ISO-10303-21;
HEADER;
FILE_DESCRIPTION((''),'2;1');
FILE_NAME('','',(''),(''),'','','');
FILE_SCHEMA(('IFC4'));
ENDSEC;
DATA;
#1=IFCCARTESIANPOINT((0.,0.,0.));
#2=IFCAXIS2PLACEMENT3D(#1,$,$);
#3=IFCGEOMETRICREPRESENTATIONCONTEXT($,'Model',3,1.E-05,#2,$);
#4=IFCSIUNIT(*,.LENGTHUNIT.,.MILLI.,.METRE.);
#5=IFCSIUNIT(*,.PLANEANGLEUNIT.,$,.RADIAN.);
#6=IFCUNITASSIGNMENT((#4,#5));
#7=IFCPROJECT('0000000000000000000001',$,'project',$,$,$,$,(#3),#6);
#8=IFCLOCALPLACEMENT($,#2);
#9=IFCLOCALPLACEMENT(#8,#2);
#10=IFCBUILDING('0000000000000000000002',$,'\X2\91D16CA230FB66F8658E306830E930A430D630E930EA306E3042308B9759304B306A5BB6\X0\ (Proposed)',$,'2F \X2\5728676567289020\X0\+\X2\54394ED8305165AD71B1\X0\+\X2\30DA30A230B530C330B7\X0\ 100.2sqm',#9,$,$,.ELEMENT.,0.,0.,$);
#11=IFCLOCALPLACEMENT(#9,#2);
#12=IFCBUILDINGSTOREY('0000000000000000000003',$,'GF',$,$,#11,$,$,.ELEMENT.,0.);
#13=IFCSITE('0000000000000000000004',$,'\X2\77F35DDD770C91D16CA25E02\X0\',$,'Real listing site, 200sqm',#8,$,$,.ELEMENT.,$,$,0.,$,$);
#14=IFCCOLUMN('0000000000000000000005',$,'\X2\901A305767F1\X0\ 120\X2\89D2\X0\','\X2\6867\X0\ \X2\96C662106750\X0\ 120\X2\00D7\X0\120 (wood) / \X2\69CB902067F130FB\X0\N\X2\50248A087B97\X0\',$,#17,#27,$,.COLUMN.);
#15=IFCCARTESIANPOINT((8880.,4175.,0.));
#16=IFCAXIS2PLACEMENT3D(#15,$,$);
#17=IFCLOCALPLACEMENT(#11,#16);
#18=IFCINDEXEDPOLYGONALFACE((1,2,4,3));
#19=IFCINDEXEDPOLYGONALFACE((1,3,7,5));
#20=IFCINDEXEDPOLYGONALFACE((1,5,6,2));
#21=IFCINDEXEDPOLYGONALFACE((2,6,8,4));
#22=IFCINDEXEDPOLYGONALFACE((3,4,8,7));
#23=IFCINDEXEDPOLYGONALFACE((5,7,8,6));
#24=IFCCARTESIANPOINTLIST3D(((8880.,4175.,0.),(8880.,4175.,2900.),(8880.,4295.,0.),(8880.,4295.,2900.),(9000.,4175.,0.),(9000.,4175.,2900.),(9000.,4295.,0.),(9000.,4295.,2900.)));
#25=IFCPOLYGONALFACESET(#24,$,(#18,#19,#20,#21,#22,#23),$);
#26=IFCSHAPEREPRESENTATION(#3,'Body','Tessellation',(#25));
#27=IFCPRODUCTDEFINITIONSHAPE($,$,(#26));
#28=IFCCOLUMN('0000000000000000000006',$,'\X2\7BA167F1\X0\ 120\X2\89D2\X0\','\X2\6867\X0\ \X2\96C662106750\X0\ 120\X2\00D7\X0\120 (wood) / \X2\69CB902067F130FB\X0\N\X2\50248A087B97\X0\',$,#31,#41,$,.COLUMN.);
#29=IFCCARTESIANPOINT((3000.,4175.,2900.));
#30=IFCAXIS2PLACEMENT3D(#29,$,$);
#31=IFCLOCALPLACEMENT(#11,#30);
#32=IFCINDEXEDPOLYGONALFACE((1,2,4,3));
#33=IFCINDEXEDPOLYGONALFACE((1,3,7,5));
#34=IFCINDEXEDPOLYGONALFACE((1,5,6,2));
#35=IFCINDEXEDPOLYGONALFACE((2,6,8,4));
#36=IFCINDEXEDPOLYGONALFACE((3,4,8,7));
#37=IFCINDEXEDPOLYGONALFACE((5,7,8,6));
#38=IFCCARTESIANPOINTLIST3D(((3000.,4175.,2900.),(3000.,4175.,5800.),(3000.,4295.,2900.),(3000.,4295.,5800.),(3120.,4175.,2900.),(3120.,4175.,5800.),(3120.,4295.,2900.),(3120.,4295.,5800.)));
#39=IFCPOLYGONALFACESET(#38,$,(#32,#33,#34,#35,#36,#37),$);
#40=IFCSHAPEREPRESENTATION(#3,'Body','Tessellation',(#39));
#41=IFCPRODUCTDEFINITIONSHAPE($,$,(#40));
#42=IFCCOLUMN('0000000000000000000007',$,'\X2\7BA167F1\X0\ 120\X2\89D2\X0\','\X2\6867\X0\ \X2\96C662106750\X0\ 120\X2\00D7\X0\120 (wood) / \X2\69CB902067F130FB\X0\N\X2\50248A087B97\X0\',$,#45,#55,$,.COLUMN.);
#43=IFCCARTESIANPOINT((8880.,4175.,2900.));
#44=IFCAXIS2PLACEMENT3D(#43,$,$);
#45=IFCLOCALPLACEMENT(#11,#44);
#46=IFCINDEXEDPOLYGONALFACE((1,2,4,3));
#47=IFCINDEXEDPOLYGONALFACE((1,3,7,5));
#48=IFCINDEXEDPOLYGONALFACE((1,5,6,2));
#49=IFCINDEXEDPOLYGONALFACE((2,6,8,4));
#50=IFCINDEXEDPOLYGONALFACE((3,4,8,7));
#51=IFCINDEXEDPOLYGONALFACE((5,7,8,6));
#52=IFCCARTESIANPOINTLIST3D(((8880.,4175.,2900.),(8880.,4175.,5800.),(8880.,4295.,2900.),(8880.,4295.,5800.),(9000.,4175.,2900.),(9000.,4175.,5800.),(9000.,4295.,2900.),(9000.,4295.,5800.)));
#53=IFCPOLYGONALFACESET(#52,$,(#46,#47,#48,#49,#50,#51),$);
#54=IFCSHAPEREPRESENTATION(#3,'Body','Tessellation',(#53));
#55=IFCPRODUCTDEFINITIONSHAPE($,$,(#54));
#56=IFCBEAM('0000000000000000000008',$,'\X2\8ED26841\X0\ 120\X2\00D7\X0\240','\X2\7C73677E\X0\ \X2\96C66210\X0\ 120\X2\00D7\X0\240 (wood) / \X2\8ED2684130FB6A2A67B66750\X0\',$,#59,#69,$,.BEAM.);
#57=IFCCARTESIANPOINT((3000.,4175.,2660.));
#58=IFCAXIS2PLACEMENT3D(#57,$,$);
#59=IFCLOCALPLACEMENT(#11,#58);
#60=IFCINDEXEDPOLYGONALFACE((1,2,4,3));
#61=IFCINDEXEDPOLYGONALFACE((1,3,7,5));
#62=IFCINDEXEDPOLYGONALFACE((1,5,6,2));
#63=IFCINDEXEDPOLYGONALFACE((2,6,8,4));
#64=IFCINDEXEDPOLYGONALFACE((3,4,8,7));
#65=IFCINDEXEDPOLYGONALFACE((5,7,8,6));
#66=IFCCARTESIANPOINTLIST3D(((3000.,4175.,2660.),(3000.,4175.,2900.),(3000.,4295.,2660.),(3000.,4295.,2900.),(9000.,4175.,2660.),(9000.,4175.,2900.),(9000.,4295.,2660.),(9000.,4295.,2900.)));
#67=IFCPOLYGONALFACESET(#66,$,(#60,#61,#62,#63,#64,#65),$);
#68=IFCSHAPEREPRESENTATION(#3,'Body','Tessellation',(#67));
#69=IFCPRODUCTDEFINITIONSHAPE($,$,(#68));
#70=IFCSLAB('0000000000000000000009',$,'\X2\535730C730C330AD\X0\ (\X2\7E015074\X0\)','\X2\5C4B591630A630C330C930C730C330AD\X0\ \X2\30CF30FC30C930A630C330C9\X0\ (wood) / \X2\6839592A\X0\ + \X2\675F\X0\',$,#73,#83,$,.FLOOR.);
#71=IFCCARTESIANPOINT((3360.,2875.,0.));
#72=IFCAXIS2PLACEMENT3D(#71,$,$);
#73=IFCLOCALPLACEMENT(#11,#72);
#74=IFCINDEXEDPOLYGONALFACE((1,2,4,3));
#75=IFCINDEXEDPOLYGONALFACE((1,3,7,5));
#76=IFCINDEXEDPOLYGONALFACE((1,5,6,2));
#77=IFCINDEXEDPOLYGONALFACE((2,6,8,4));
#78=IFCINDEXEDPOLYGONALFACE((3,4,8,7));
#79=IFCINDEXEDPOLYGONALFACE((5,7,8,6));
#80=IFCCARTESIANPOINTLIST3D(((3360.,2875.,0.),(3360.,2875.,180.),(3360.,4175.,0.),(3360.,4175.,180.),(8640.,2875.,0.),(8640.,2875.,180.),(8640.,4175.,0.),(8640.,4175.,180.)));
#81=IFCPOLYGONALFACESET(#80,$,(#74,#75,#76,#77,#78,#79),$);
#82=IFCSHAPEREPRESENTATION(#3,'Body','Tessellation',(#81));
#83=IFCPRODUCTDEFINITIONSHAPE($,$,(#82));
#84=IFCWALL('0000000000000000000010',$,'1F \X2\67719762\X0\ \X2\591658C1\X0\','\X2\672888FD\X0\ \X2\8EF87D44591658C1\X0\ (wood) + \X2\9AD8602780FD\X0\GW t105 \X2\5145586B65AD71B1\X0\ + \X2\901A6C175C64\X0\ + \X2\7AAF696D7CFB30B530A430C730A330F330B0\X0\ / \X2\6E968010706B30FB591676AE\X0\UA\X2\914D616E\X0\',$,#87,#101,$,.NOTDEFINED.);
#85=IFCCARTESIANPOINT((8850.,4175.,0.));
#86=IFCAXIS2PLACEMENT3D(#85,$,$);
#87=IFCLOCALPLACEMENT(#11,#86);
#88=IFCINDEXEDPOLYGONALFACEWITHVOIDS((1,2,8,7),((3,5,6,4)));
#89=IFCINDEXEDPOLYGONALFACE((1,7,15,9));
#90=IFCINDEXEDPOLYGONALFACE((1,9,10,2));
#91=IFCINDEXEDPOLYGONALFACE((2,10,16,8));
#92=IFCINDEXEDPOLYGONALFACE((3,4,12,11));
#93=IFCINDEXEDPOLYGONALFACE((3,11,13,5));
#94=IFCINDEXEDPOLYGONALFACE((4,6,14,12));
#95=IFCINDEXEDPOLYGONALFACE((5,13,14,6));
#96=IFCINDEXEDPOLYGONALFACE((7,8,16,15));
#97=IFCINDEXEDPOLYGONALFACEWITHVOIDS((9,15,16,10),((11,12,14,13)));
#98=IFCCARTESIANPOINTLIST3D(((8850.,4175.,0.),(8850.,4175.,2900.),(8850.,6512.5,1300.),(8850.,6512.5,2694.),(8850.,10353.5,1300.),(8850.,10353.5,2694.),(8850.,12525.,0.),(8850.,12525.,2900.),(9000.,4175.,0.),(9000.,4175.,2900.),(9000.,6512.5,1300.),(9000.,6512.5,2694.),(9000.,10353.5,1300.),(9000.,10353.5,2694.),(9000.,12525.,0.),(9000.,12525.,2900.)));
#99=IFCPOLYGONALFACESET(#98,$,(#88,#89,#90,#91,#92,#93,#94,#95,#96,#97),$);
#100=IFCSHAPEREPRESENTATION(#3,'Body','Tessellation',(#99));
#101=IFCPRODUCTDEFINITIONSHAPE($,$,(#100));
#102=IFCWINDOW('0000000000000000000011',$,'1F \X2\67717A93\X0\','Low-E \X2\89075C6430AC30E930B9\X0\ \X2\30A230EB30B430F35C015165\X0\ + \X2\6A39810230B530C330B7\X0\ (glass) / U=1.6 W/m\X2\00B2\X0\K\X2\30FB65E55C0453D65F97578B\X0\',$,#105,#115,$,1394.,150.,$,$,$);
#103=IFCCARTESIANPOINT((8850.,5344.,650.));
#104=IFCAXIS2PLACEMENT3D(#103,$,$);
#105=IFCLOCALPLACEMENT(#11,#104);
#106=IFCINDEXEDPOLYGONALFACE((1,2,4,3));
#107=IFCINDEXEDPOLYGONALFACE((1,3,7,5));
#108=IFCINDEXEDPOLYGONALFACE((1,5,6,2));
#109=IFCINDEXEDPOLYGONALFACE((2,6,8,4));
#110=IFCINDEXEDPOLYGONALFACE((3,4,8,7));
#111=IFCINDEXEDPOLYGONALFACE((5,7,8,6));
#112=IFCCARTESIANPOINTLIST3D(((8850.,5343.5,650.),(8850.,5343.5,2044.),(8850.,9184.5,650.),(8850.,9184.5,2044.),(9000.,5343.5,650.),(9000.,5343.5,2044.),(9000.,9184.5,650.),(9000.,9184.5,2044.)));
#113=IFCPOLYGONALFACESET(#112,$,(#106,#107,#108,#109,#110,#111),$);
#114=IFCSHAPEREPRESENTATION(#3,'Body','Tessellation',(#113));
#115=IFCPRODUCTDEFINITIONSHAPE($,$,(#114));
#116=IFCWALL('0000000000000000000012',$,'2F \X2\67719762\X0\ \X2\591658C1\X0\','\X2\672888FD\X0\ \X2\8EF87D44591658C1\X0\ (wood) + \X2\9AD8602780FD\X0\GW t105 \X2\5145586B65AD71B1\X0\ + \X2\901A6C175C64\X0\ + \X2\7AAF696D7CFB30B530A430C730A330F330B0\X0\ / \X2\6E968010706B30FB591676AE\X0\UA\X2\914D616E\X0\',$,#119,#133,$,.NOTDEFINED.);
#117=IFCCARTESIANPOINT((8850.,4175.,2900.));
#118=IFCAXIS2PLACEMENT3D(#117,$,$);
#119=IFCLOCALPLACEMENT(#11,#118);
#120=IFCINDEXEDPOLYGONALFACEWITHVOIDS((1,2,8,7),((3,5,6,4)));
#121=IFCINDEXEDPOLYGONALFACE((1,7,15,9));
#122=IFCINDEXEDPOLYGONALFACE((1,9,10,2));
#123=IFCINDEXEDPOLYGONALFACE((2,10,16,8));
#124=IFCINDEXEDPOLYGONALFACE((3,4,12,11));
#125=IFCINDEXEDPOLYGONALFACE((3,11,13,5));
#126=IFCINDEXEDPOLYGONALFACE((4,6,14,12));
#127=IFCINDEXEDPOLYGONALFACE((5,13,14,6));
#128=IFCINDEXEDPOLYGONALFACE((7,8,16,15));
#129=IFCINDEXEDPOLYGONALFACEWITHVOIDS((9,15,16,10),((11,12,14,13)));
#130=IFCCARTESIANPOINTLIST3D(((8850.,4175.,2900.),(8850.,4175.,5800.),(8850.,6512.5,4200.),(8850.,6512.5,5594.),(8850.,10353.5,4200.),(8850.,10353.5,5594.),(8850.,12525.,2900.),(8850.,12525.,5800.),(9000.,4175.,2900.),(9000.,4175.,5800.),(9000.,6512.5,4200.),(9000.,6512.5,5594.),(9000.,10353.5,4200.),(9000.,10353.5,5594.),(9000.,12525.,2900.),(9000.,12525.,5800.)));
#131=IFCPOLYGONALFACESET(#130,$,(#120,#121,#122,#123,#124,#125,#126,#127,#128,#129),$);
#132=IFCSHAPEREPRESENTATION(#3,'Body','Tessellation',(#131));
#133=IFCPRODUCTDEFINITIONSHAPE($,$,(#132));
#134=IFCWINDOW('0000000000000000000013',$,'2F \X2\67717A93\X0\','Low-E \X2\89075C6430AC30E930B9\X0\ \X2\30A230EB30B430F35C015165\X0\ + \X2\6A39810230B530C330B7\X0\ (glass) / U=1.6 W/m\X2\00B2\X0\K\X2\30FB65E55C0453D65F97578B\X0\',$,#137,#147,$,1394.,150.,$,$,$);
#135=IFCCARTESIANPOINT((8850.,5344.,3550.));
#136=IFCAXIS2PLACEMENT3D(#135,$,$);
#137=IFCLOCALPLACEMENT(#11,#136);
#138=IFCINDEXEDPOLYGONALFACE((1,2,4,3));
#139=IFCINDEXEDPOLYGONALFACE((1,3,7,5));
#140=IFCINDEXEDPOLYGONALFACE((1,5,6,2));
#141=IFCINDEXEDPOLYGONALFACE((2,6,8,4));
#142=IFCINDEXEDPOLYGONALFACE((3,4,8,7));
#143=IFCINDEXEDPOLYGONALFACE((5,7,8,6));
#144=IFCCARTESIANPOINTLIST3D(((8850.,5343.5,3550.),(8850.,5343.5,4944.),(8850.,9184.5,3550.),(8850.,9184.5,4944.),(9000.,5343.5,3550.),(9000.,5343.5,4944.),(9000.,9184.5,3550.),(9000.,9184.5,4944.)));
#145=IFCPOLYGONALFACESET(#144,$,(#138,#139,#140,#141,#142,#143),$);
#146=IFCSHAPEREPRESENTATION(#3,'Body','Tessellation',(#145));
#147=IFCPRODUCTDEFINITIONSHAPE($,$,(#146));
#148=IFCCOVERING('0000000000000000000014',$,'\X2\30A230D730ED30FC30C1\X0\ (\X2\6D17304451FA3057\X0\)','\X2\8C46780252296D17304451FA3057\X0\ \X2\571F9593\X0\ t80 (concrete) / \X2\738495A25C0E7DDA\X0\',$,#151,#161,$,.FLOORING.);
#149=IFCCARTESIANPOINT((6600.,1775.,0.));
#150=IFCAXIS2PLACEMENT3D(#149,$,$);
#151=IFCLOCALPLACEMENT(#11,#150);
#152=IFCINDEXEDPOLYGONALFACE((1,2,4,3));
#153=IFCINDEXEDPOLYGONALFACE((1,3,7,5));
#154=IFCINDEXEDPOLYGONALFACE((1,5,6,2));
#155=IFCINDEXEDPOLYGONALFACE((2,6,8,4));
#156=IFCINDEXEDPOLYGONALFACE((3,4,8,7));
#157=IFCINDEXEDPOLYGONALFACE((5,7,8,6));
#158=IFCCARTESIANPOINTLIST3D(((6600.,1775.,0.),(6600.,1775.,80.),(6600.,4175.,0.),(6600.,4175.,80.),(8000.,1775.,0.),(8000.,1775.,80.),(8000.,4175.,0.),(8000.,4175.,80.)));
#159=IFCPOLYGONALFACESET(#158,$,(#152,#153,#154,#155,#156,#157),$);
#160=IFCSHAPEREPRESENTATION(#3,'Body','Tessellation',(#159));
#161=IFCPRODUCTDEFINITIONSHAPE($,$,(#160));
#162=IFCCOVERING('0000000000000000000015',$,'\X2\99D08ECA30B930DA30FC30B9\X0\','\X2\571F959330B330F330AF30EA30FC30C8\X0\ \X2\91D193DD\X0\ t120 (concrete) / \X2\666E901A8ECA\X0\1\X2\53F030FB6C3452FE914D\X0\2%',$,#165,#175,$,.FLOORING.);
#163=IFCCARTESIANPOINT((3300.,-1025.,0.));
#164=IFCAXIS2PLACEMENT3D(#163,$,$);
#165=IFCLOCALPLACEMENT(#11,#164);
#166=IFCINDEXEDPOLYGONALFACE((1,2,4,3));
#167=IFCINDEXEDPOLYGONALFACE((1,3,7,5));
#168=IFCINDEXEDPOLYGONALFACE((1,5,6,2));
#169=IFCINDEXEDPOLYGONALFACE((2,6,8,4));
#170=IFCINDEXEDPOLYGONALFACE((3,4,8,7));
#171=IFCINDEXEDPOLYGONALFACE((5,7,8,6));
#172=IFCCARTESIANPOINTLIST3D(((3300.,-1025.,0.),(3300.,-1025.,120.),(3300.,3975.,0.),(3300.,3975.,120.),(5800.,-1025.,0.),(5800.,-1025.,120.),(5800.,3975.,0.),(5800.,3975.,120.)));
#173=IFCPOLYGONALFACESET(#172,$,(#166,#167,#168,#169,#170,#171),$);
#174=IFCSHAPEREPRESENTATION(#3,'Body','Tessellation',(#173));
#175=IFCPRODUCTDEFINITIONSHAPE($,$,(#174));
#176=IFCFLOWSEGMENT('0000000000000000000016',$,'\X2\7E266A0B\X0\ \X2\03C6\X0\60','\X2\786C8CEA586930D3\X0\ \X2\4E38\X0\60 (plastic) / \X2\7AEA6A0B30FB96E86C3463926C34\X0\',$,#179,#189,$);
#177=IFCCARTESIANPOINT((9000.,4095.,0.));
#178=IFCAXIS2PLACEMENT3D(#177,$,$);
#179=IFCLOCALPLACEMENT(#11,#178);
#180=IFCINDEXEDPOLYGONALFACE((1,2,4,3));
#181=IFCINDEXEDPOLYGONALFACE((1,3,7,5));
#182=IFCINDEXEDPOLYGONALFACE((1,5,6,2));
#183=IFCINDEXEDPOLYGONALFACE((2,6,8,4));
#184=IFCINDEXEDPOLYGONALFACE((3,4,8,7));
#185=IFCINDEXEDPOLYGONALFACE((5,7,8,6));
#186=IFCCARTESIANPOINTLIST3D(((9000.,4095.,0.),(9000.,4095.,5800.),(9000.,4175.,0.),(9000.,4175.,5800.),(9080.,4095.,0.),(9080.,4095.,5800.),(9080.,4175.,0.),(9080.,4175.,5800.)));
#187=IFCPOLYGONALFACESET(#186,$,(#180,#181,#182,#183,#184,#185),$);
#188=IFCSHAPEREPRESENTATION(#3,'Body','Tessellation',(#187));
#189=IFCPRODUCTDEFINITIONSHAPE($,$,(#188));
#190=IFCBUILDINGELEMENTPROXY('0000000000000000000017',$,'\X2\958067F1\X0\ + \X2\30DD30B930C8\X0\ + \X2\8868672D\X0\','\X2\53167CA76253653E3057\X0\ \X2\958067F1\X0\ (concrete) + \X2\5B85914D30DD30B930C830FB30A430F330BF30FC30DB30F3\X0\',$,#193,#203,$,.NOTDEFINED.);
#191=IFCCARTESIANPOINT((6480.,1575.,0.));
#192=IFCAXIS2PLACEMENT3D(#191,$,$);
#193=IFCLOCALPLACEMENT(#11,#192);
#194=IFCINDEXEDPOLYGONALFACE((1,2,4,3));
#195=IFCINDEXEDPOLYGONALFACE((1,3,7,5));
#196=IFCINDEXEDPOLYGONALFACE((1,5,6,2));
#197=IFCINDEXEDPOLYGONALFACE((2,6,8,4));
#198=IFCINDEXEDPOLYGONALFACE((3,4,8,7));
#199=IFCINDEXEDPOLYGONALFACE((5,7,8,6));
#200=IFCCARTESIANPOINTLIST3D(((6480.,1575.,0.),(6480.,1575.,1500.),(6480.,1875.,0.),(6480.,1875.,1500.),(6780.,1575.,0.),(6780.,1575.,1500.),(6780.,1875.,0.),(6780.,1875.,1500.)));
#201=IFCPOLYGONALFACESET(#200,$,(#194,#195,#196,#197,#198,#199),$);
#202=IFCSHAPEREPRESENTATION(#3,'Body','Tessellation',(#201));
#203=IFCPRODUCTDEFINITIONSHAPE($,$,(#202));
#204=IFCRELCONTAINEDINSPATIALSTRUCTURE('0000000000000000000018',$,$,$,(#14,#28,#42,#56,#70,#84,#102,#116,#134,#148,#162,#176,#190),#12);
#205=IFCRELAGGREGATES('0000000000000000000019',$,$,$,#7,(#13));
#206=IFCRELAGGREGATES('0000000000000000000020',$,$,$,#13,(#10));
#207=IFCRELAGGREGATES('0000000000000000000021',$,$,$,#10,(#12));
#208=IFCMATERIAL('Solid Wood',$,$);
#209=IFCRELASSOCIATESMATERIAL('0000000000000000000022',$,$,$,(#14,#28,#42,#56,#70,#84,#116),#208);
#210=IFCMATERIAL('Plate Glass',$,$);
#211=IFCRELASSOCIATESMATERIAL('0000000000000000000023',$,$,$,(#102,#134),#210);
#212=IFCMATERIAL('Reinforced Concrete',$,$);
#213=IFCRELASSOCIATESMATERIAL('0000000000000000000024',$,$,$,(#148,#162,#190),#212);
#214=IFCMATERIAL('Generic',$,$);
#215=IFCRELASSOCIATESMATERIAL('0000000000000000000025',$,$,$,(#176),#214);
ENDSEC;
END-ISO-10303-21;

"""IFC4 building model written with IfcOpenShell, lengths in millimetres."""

from ifc_helpers import new_model, si_unit, frame, frame_2d, origin, place, context, project, spatial, rectangle, extrude, material, element, fill, save


model = new_model("IFC4")

# Units and contexts
model_context = context("Model", 3, precision=1e-05, world=origin())
ifc_project = project(units=[si_unit("LENGTHUNIT", "METRE", prefix="MILLI"), si_unit("PLANEANGLEUNIT", "RADIAN")], contexts=[model_context])

# Site, building, storey
site_placement = place(None, origin())
site = spatial("IfcSite", under=ifc_project, at=site_placement, Name="石川県金沢市", ObjectType="Real listing site, 200sqm", CompositionType="ELEMENT", RefElevation=0.0)
building_placement = place(site_placement, origin())
building = spatial("IfcBuilding", under=site, at=building_placement, Name="金沢・書斎とライブラリのある静かな家 (Proposed)", ObjectType="2F 在来木造+吹付け断熱+ペアサッシ 100.2sqm", CompositionType="ELEMENT", ElevationOfRefHeight=0.0, ElevationOfTerrain=0.0)
storey_placement = place(building_placement, origin())
storey = spatial("IfcBuildingStorey", under=building, at=storey_placement, Name="GF", CompositionType="ELEMENT", Elevation=0.0)

# Columns
ifc_material_1 = material(Name="Solid Wood")
column_1_placement = place(storey_placement, frame((8880.0, 4175.0, 0.0)))
element("IfcColumn", 1, at=column_1_placement, inside=storey, material=ifc_material_1, Name="通し柱 120角", Description="桧 集成材 120×120 (wood) / 構造柱・N値計算", PredefinedType="COLUMN", context=model_context, shape_type="SweptSolid", body=[
    extrude(rectangle(XDim=120.0, YDim=120.0, at=frame_2d((60.0, 60.0))), frame((8880.0, 4175.0, 0.0)), (0.0, 0.0, 1.0), 2900.0),
])
column_2_placement = place(storey_placement, frame((3000.0, 4175.0, 2900.0)))
element("IfcColumn", 2, at=column_2_placement, inside=storey, material=ifc_material_1, Name="管柱 120角", Description="桧 集成材 120×120 (wood) / 構造柱・N値計算", PredefinedType="COLUMN", context=model_context, shape_type="SweptSolid", body=[
    extrude(rectangle(XDim=120.0, YDim=120.0, at=frame_2d((60.0, 60.0))), frame((3000.0, 4175.0, 2900.0)), (0.0, 0.0, 1.0), 2900.0),
])
column_3_placement = place(storey_placement, frame((8880.0, 4175.0, 2900.0)))
element("IfcColumn", 3, at=column_3_placement, inside=storey, material=ifc_material_1, Name="管柱 120角", Description="桧 集成材 120×120 (wood) / 構造柱・N値計算", PredefinedType="COLUMN", context=model_context, shape_type="SweptSolid", body=[
    extrude(rectangle(XDim=120.0, YDim=120.0, at=frame_2d((60.0, 60.0))), frame((8880.0, 4175.0, 2900.0)), (0.0, 0.0, 1.0), 2900.0),
])

# Beam
beam_1_placement = place(storey_placement, frame((3000.0, 4175.0, 2660.0)))
element("IfcBeam", 4, at=beam_1_placement, inside=storey, material=ifc_material_1, Name="軒桁 120×240", Description="米松 集成 120×240 (wood) / 軒桁・横架材", PredefinedType="BEAM", context=model_context, shape_type="SweptSolid", body=[
    extrude(rectangle(XDim=6000.0, YDim=120.0, at=frame_2d((3000.0, 60.0))), frame((3000.0, 4175.0, 2660.0)), (0.0, 0.0, 1.0), 240.0),
])

# Slab
slab_placement = place(storey_placement, frame((3360.0, 2875.0, 0.0)))
element("IfcSlab", 5, at=slab_placement, inside=storey, material=ifc_material_1, Name="南デッキ (縁側)", Description="屋外ウッドデッキ ハードウッド (wood) / 根太 + 束", PredefinedType="FLOOR", context=model_context, shape_type="SweptSolid", body=[
    extrude(rectangle(XDim=5280.0, YDim=1300.0, at=frame_2d((2640.0, 650.0))), frame((3360.0, 2875.0, 0.0)), (0.0, 0.0, 1.0), 180.0),
])

# Walls, openings, windows
wall_1_placement = place(storey_placement, frame((8850.0, 4175.0, 0.0)))
wall_1 = element("IfcWall", 6, at=wall_1_placement, inside=storey, material=ifc_material_1, Name="1F 東面 外壁", Description="木製 軸組外壁 (wood) + 高性能GW t105 充填断熱 + 通気層 + 窯業系サイディング / 準耐火・外皮UA配慮", PredefinedType="NOTDEFINED", context=model_context, shape_type="SweptSolid", body=[
    extrude(rectangle(XDim=150.0, YDim=8350.0, at=frame_2d((75.0, 4175.0))), frame((8850.0, 4175.0, 0.0)), (0.0, 0.0, 1.0), 2900.0),
])
opening_1_placement = place(storey_placement, frame((8850.0, 5344.0, 650.0)))
opening_1 = element("IfcOpeningElement", 7, at=opening_1_placement, cuts=wall_1, PredefinedType="NOTDEFINED", context=model_context, shape_type="SweptSolid", body=[
    extrude(rectangle(XDim=150.0, YDim=3841.0, at=frame_2d((75.0, 1920.0))), frame((8850.0, 5344.0, 650.0)), (0.0, 0.0, 1.0), 1394.0),
])
ifc_material_2 = material(Name="Plate Glass")
window_1_placement = place(storey_placement, frame((8850.0, 5344.0, 650.0)))
window_1 = element("IfcWindow", 8, at=window_1_placement, inside=storey, material=ifc_material_2, Name="1F 東窓", Description="Low-E 複層ガラス アルゴン封入 + 樹脂サッシ (glass) / U=1.6 W/m²K・日射取得型", OverallHeight=1394.0, OverallWidth=150.0, context=model_context, shape_type="SweptSolid", body=[
    extrude(rectangle(XDim=150.0, YDim=3841.0, at=frame_2d((75.0, 1920.0))), frame((8850.0, 5344.0, 650.0)), (0.0, 0.0, 1.0), 1394.0),
])
fill(opening_1, window_1)
wall_2_placement = place(storey_placement, frame((8850.0, 4175.0, 2900.0)))
wall_2 = element("IfcWall", 9, at=wall_2_placement, inside=storey, material=ifc_material_1, Name="2F 東面 外壁", Description="木製 軸組外壁 (wood) + 高性能GW t105 充填断熱 + 通気層 + 窯業系サイディング / 準耐火・外皮UA配慮", PredefinedType="NOTDEFINED", context=model_context, shape_type="SweptSolid", body=[
    extrude(rectangle(XDim=150.0, YDim=8350.0, at=frame_2d((75.0, 4175.0))), frame((8850.0, 4175.0, 2900.0)), (0.0, 0.0, 1.0), 2900.0),
])
opening_2_placement = place(storey_placement, frame((8850.0, 5344.0, 3550.0)))
opening_2 = element("IfcOpeningElement", 10, at=opening_2_placement, cuts=wall_2, PredefinedType="NOTDEFINED", context=model_context, shape_type="SweptSolid", body=[
    extrude(rectangle(XDim=150.0, YDim=3841.0, at=frame_2d((75.0, 1920.0))), frame((8850.0, 5344.0, 3550.0)), (0.0, 0.0, 1.0), 1394.0),
])
window_2_placement = place(storey_placement, frame((8850.0, 5344.0, 3550.0)))
window_2 = element("IfcWindow", 11, at=window_2_placement, inside=storey, material=ifc_material_2, Name="2F 東窓", Description="Low-E 複層ガラス アルゴン封入 + 樹脂サッシ (glass) / U=1.6 W/m²K・日射取得型", OverallHeight=1394.0, OverallWidth=150.0, context=model_context, shape_type="SweptSolid", body=[
    extrude(rectangle(XDim=150.0, YDim=3841.0, at=frame_2d((75.0, 1920.0))), frame((8850.0, 5344.0, 3550.0)), (0.0, 0.0, 1.0), 1394.0),
])
fill(opening_2, window_2)

# Coverings
ifc_material_3 = material(Name="Reinforced Concrete")
covering_1_placement = place(storey_placement, frame((6600.0, 1775.0, 0.0)))
element("IfcCovering", 12, at=covering_1_placement, inside=storey, material=ifc_material_3, Name="アプローチ (洗い出し)", Description="豆砂利洗い出し 土間 t80 (concrete) / 玄関導線", PredefinedType="FLOORING", context=model_context, shape_type="SweptSolid", body=[
    extrude(rectangle(XDim=1400.0, YDim=2400.0, at=frame_2d((700.0, 1200.0))), frame((6600.0, 1775.0, 0.0)), (0.0, 0.0, 1.0), 80.0),
])
covering_2_placement = place(storey_placement, frame((3300.0, -1025.0, 0.0)))
element("IfcCovering", 13, at=covering_2_placement, inside=storey, material=ifc_material_3, Name="駐車スペース", Description="土間コンクリート 金鏝 t120 (concrete) / 普通車1台・水勾配2%", PredefinedType="FLOORING", context=model_context, shape_type="SweptSolid", body=[
    extrude(rectangle(XDim=2500.0, YDim=5000.0, at=frame_2d((1250.0, 2500.0))), frame((3300.0, -1025.0, 0.0)), (0.0, 0.0, 1.0), 120.0),
])

# Flow segment
ifc_material_4 = material(Name="Generic")
flow_segment_placement = place(storey_placement, frame((9000.0, 4095.0, 0.0)))
element("IfcFlowSegment", 14, at=flow_segment_placement, inside=storey, material=ifc_material_4, Name="縦樋 φ60", Description="硬質塩ビ 丸60 (plastic) / 竪樋・雨水排水", context=model_context, shape_type="SweptSolid", body=[
    extrude(rectangle(XDim=80.0, YDim=80.0, at=frame_2d((40.0, 40.0))), frame((9000.0, 4095.0, 0.0)), (0.0, 0.0, 1.0), 5800.0),
])

# Building element proxy
proxy_placement = place(storey_placement, frame((6480.0, 1575.0, 0.0)))
element("IfcBuildingElementProxy", 15, at=proxy_placement, inside=storey, material=ifc_material_3, Name="門柱 + ポスト + 表札", Description="化粧打放し 門柱 (concrete) + 宅配ポスト・インターホン", PredefinedType="NOTDEFINED", context=model_context, shape_type="SweptSolid", body=[
    extrude(rectangle(XDim=300.0, YDim=300.0, at=frame_2d((150.0, 150.0))), frame((6480.0, 1575.0, 0.0)), (0.0, 0.0, 1.0), 1500.0),
])

save(model, "model.ifc")
